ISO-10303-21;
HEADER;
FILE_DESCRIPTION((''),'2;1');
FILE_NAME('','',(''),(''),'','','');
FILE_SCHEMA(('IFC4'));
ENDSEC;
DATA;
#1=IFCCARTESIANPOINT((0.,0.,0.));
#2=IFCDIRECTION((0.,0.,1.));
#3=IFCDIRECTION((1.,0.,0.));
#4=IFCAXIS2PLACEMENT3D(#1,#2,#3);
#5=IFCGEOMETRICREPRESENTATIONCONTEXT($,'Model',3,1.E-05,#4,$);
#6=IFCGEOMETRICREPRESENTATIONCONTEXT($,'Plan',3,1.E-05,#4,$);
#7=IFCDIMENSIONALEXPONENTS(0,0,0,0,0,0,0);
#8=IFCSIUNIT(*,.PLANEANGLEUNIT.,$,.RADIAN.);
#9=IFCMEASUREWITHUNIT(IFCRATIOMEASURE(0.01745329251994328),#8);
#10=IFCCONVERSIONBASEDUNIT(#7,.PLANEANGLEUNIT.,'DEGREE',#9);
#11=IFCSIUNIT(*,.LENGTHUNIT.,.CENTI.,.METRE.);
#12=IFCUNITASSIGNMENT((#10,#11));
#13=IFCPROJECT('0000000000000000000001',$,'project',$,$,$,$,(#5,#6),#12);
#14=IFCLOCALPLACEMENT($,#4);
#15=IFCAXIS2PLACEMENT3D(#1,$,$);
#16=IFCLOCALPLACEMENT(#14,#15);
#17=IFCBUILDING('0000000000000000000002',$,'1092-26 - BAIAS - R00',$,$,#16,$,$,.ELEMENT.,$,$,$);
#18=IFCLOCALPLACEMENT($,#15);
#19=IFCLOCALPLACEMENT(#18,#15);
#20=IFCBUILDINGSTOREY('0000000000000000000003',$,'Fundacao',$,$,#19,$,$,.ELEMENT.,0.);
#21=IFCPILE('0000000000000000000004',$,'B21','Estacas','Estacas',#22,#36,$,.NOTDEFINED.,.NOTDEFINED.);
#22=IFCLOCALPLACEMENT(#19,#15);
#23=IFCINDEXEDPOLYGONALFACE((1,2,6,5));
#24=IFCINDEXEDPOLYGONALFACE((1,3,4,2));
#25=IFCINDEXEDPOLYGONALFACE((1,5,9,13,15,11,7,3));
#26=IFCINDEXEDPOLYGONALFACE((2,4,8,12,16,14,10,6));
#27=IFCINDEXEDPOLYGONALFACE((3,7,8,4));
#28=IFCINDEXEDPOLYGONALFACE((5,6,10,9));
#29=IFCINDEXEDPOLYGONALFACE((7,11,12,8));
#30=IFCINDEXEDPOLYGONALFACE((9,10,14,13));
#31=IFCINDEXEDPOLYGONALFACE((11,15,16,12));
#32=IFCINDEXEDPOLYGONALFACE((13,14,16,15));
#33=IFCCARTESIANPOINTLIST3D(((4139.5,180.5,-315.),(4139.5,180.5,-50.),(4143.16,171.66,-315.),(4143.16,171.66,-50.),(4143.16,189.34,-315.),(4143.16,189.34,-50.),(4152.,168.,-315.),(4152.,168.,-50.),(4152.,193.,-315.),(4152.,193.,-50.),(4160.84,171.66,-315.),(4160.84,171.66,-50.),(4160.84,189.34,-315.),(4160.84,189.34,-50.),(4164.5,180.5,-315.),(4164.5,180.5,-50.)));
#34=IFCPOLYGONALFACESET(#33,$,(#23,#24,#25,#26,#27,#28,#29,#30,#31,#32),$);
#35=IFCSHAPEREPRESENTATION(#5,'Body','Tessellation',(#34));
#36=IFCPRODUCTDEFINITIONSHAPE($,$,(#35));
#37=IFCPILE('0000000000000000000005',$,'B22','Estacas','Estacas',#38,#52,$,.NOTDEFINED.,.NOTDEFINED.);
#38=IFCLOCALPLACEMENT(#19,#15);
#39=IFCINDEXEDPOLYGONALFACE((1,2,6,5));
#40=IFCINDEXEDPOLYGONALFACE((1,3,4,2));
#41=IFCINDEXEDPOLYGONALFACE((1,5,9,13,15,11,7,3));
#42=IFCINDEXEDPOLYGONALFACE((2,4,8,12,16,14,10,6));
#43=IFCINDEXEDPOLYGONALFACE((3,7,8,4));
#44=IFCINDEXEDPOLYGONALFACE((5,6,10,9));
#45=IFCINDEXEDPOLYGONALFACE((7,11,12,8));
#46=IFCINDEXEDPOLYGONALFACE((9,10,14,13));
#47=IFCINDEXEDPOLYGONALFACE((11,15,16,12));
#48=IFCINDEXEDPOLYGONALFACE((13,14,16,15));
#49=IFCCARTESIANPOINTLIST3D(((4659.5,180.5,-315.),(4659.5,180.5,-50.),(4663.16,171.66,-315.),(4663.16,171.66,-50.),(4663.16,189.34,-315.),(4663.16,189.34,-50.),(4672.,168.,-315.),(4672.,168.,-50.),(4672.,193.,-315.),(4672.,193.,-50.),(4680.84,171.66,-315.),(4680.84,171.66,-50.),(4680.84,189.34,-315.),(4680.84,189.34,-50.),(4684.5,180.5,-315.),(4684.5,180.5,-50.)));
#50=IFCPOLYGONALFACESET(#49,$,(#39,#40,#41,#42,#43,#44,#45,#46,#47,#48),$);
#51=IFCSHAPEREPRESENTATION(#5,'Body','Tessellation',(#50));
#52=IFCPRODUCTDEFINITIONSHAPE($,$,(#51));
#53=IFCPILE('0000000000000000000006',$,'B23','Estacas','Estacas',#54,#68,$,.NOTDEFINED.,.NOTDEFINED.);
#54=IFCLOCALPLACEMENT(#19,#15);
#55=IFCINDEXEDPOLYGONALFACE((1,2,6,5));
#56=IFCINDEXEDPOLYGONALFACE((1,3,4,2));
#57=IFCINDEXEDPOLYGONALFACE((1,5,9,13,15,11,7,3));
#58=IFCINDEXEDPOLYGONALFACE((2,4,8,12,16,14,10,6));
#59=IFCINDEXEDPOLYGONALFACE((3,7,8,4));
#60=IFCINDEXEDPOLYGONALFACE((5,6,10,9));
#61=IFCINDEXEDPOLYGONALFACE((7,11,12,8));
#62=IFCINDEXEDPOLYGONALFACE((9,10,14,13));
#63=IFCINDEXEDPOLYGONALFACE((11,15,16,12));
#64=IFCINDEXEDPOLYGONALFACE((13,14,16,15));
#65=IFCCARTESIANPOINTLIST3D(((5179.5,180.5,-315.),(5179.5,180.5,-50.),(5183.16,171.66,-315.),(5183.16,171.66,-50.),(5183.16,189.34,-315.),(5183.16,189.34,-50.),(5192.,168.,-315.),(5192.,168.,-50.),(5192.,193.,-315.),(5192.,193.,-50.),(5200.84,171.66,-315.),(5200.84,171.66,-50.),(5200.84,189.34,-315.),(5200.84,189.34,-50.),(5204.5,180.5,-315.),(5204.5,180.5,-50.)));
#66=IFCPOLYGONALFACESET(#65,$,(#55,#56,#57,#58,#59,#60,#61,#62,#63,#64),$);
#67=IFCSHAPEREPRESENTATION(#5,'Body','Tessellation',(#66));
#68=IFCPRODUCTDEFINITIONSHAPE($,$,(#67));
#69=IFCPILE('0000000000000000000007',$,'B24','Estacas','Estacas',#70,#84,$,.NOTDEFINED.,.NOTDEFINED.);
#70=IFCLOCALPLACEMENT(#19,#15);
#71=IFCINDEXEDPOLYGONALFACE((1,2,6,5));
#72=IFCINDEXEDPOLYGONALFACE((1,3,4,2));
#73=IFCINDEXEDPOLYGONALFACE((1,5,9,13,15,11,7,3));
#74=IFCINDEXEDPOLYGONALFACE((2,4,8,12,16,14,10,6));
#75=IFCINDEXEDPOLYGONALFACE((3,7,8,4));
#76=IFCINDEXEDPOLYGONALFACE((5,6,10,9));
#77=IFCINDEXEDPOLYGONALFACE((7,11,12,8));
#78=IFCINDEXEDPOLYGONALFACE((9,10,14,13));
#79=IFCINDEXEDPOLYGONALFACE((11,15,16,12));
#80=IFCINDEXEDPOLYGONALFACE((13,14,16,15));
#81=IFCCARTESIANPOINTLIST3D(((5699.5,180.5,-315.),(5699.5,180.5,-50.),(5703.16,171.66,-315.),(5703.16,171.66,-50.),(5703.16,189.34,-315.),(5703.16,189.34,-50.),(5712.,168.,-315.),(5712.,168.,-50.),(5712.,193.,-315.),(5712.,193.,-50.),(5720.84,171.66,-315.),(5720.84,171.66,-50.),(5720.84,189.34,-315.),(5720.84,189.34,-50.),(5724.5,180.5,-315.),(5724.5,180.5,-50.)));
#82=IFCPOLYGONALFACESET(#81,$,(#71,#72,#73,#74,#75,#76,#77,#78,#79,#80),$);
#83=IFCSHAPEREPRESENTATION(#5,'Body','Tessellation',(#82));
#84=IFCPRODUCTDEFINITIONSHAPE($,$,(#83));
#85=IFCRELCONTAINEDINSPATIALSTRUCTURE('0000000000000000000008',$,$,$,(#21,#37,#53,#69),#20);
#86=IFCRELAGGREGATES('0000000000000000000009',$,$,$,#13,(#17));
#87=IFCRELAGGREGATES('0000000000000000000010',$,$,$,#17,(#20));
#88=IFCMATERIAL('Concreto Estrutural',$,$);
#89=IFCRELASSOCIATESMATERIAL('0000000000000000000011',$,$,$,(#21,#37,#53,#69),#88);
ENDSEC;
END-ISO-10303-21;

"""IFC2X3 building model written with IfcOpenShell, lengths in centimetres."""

from ifc_helpers import new_model, entity, si_unit, converted_unit, frame, origin, origin_with_axes, place, context, project, spatial, polyline, outline, extrude, material, element, save


model = new_model("IFC2X3")

# Units and contexts
model_context = context("Model", 3, precision=1e-05, world=origin_with_axes())
plan_context = context("Plan", 3, precision=1e-05, world=origin_with_axes())
ifc_project = project(units=[converted_unit("PLANEANGLEUNIT", "DEGREE", entity("IfcRatioMeasure", 0.01745329251994328), si_unit("PLANEANGLEUNIT", "RADIAN"), dimensions=[0, 0, 0, 0, 0, 0, 0]), si_unit("LENGTHUNIT", "METRE", prefix="CENTI")], contexts=[model_context, plan_context])

# Building, storey
placement_1 = place(None, origin_with_axes())
building_placement = place(placement_1, origin())
building = spatial("IfcBuilding", under=ifc_project, at=building_placement, Name="1092-26 - BAIAS - R00", CompositionType="ELEMENT")
placement_2 = place(None, origin())
storey_placement = place(placement_2, origin())
storey = spatial("IfcBuildingStorey", under=building, at=storey_placement, Name="Fundacao", CompositionType="ELEMENT", Elevation=0.0)

# Piles
ifc_material_1 = material(Name="Concreto Estrutural")
placement_3 = place(None, origin_with_axes())
placement_4 = place(placement_3, origin_with_axes())
placement_5 = place(placement_4, origin_with_axes())
pile_1_placement = place(placement_5, frame((4152.0, 180.5, -315.0), z_axis=(0.0, 0.0, 1.0), x_axis=(1.0, 0.0, 0.0)))
element("IfcPile", 1, at=pile_1_placement, inside=storey, material=ifc_material_1, Name="B21", Description="Estacas", ObjectType="Estacas", ConstructionType="NOTDEFINED", PredefinedType="NOTDEFINED", context=model_context, shape_type="SweptSolid", body=[
    extrude(outline(polyline([(8.84, -8.84, 0.0), (0.0, -12.5, 0.0), (-8.84, -8.84, 0.0), (-12.5, 0.0, 0.0), (-8.84, 8.84, 0.0), (0.0, 12.5, 0.0), (8.84, 8.84, 0.0), (12.5, 0.0, 0.0), (8.84, -8.84, 0.0)])), origin_with_axes(), (0.0, 0.0, 1.0), 265.0),
])
placement_6 = place(placement_4, origin_with_axes())
pile_2_placement = place(placement_6, frame((4672.0, 180.5, -315.0), z_axis=(0.0, 0.0, 1.0), x_axis=(1.0, 0.0, 0.0)))
element("IfcPile", 2, at=pile_2_placement, inside=storey, material=ifc_material_1, Name="B22", Description="Estacas", ObjectType="Estacas", ConstructionType="NOTDEFINED", PredefinedType="NOTDEFINED", context=model_context, shape_type="SweptSolid", body=[
    extrude(outline(polyline([(8.84, -8.84, 0.0), (0.0, -12.5, 0.0), (-8.84, -8.84, 0.0), (-12.5, 0.0, 0.0), (-8.84, 8.84, 0.0), (0.0, 12.5, 0.0), (8.84, 8.84, 0.0), (12.5, 0.0, 0.0), (8.84, -8.84, 0.0)])), origin_with_axes(), (0.0, 0.0, 1.0), 265.0),
])
placement_7 = place(placement_4, origin_with_axes())
pile_3_placement = place(placement_7, frame((5192.0, 180.5, -315.0), z_axis=(0.0, 0.0, 1.0), x_axis=(1.0, 0.0, 0.0)))
element("IfcPile", 3, at=pile_3_placement, inside=storey, material=ifc_material_1, Name="B23", Description="Estacas", ObjectType="Estacas", ConstructionType="NOTDEFINED", PredefinedType="NOTDEFINED", context=model_context, shape_type="SweptSolid", body=[
    extrude(outline(polyline([(8.84, -8.84, 0.0), (0.0, -12.5, 0.0), (-8.84, -8.84, 0.0), (-12.5, 0.0, 0.0), (-8.84, 8.84, 0.0), (0.0, 12.5, 0.0), (8.84, 8.84, 0.0), (12.5, 0.0, 0.0), (8.84, -8.84, 0.0)])), origin_with_axes(), (0.0, 0.0, 1.0), 265.0),
])
placement_8 = place(placement_4, origin_with_axes())
pile_4_placement = place(placement_8, frame((5712.0, 180.5, -315.0), z_axis=(0.0, 0.0, 1.0), x_axis=(1.0, 0.0, 0.0)))
element("IfcPile", 4, at=pile_4_placement, inside=storey, material=ifc_material_1, Name="B24", Description="Estacas", ObjectType="Estacas", ConstructionType="NOTDEFINED", PredefinedType="NOTDEFINED", context=model_context, shape_type="SweptSolid", body=[
    extrude(outline(polyline([(8.84, -8.84, 0.0), (0.0, -12.5, 0.0), (-8.84, -8.84, 0.0), (-12.5, 0.0, 0.0), (-8.84, 8.84, 0.0), (0.0, 12.5, 0.0), (8.84, 8.84, 0.0), (12.5, 0.0, 0.0), (8.84, -8.84, 0.0)])), origin_with_axes(), (0.0, 0.0, 1.0), 265.0),
])

save(model, "model.ifc")
